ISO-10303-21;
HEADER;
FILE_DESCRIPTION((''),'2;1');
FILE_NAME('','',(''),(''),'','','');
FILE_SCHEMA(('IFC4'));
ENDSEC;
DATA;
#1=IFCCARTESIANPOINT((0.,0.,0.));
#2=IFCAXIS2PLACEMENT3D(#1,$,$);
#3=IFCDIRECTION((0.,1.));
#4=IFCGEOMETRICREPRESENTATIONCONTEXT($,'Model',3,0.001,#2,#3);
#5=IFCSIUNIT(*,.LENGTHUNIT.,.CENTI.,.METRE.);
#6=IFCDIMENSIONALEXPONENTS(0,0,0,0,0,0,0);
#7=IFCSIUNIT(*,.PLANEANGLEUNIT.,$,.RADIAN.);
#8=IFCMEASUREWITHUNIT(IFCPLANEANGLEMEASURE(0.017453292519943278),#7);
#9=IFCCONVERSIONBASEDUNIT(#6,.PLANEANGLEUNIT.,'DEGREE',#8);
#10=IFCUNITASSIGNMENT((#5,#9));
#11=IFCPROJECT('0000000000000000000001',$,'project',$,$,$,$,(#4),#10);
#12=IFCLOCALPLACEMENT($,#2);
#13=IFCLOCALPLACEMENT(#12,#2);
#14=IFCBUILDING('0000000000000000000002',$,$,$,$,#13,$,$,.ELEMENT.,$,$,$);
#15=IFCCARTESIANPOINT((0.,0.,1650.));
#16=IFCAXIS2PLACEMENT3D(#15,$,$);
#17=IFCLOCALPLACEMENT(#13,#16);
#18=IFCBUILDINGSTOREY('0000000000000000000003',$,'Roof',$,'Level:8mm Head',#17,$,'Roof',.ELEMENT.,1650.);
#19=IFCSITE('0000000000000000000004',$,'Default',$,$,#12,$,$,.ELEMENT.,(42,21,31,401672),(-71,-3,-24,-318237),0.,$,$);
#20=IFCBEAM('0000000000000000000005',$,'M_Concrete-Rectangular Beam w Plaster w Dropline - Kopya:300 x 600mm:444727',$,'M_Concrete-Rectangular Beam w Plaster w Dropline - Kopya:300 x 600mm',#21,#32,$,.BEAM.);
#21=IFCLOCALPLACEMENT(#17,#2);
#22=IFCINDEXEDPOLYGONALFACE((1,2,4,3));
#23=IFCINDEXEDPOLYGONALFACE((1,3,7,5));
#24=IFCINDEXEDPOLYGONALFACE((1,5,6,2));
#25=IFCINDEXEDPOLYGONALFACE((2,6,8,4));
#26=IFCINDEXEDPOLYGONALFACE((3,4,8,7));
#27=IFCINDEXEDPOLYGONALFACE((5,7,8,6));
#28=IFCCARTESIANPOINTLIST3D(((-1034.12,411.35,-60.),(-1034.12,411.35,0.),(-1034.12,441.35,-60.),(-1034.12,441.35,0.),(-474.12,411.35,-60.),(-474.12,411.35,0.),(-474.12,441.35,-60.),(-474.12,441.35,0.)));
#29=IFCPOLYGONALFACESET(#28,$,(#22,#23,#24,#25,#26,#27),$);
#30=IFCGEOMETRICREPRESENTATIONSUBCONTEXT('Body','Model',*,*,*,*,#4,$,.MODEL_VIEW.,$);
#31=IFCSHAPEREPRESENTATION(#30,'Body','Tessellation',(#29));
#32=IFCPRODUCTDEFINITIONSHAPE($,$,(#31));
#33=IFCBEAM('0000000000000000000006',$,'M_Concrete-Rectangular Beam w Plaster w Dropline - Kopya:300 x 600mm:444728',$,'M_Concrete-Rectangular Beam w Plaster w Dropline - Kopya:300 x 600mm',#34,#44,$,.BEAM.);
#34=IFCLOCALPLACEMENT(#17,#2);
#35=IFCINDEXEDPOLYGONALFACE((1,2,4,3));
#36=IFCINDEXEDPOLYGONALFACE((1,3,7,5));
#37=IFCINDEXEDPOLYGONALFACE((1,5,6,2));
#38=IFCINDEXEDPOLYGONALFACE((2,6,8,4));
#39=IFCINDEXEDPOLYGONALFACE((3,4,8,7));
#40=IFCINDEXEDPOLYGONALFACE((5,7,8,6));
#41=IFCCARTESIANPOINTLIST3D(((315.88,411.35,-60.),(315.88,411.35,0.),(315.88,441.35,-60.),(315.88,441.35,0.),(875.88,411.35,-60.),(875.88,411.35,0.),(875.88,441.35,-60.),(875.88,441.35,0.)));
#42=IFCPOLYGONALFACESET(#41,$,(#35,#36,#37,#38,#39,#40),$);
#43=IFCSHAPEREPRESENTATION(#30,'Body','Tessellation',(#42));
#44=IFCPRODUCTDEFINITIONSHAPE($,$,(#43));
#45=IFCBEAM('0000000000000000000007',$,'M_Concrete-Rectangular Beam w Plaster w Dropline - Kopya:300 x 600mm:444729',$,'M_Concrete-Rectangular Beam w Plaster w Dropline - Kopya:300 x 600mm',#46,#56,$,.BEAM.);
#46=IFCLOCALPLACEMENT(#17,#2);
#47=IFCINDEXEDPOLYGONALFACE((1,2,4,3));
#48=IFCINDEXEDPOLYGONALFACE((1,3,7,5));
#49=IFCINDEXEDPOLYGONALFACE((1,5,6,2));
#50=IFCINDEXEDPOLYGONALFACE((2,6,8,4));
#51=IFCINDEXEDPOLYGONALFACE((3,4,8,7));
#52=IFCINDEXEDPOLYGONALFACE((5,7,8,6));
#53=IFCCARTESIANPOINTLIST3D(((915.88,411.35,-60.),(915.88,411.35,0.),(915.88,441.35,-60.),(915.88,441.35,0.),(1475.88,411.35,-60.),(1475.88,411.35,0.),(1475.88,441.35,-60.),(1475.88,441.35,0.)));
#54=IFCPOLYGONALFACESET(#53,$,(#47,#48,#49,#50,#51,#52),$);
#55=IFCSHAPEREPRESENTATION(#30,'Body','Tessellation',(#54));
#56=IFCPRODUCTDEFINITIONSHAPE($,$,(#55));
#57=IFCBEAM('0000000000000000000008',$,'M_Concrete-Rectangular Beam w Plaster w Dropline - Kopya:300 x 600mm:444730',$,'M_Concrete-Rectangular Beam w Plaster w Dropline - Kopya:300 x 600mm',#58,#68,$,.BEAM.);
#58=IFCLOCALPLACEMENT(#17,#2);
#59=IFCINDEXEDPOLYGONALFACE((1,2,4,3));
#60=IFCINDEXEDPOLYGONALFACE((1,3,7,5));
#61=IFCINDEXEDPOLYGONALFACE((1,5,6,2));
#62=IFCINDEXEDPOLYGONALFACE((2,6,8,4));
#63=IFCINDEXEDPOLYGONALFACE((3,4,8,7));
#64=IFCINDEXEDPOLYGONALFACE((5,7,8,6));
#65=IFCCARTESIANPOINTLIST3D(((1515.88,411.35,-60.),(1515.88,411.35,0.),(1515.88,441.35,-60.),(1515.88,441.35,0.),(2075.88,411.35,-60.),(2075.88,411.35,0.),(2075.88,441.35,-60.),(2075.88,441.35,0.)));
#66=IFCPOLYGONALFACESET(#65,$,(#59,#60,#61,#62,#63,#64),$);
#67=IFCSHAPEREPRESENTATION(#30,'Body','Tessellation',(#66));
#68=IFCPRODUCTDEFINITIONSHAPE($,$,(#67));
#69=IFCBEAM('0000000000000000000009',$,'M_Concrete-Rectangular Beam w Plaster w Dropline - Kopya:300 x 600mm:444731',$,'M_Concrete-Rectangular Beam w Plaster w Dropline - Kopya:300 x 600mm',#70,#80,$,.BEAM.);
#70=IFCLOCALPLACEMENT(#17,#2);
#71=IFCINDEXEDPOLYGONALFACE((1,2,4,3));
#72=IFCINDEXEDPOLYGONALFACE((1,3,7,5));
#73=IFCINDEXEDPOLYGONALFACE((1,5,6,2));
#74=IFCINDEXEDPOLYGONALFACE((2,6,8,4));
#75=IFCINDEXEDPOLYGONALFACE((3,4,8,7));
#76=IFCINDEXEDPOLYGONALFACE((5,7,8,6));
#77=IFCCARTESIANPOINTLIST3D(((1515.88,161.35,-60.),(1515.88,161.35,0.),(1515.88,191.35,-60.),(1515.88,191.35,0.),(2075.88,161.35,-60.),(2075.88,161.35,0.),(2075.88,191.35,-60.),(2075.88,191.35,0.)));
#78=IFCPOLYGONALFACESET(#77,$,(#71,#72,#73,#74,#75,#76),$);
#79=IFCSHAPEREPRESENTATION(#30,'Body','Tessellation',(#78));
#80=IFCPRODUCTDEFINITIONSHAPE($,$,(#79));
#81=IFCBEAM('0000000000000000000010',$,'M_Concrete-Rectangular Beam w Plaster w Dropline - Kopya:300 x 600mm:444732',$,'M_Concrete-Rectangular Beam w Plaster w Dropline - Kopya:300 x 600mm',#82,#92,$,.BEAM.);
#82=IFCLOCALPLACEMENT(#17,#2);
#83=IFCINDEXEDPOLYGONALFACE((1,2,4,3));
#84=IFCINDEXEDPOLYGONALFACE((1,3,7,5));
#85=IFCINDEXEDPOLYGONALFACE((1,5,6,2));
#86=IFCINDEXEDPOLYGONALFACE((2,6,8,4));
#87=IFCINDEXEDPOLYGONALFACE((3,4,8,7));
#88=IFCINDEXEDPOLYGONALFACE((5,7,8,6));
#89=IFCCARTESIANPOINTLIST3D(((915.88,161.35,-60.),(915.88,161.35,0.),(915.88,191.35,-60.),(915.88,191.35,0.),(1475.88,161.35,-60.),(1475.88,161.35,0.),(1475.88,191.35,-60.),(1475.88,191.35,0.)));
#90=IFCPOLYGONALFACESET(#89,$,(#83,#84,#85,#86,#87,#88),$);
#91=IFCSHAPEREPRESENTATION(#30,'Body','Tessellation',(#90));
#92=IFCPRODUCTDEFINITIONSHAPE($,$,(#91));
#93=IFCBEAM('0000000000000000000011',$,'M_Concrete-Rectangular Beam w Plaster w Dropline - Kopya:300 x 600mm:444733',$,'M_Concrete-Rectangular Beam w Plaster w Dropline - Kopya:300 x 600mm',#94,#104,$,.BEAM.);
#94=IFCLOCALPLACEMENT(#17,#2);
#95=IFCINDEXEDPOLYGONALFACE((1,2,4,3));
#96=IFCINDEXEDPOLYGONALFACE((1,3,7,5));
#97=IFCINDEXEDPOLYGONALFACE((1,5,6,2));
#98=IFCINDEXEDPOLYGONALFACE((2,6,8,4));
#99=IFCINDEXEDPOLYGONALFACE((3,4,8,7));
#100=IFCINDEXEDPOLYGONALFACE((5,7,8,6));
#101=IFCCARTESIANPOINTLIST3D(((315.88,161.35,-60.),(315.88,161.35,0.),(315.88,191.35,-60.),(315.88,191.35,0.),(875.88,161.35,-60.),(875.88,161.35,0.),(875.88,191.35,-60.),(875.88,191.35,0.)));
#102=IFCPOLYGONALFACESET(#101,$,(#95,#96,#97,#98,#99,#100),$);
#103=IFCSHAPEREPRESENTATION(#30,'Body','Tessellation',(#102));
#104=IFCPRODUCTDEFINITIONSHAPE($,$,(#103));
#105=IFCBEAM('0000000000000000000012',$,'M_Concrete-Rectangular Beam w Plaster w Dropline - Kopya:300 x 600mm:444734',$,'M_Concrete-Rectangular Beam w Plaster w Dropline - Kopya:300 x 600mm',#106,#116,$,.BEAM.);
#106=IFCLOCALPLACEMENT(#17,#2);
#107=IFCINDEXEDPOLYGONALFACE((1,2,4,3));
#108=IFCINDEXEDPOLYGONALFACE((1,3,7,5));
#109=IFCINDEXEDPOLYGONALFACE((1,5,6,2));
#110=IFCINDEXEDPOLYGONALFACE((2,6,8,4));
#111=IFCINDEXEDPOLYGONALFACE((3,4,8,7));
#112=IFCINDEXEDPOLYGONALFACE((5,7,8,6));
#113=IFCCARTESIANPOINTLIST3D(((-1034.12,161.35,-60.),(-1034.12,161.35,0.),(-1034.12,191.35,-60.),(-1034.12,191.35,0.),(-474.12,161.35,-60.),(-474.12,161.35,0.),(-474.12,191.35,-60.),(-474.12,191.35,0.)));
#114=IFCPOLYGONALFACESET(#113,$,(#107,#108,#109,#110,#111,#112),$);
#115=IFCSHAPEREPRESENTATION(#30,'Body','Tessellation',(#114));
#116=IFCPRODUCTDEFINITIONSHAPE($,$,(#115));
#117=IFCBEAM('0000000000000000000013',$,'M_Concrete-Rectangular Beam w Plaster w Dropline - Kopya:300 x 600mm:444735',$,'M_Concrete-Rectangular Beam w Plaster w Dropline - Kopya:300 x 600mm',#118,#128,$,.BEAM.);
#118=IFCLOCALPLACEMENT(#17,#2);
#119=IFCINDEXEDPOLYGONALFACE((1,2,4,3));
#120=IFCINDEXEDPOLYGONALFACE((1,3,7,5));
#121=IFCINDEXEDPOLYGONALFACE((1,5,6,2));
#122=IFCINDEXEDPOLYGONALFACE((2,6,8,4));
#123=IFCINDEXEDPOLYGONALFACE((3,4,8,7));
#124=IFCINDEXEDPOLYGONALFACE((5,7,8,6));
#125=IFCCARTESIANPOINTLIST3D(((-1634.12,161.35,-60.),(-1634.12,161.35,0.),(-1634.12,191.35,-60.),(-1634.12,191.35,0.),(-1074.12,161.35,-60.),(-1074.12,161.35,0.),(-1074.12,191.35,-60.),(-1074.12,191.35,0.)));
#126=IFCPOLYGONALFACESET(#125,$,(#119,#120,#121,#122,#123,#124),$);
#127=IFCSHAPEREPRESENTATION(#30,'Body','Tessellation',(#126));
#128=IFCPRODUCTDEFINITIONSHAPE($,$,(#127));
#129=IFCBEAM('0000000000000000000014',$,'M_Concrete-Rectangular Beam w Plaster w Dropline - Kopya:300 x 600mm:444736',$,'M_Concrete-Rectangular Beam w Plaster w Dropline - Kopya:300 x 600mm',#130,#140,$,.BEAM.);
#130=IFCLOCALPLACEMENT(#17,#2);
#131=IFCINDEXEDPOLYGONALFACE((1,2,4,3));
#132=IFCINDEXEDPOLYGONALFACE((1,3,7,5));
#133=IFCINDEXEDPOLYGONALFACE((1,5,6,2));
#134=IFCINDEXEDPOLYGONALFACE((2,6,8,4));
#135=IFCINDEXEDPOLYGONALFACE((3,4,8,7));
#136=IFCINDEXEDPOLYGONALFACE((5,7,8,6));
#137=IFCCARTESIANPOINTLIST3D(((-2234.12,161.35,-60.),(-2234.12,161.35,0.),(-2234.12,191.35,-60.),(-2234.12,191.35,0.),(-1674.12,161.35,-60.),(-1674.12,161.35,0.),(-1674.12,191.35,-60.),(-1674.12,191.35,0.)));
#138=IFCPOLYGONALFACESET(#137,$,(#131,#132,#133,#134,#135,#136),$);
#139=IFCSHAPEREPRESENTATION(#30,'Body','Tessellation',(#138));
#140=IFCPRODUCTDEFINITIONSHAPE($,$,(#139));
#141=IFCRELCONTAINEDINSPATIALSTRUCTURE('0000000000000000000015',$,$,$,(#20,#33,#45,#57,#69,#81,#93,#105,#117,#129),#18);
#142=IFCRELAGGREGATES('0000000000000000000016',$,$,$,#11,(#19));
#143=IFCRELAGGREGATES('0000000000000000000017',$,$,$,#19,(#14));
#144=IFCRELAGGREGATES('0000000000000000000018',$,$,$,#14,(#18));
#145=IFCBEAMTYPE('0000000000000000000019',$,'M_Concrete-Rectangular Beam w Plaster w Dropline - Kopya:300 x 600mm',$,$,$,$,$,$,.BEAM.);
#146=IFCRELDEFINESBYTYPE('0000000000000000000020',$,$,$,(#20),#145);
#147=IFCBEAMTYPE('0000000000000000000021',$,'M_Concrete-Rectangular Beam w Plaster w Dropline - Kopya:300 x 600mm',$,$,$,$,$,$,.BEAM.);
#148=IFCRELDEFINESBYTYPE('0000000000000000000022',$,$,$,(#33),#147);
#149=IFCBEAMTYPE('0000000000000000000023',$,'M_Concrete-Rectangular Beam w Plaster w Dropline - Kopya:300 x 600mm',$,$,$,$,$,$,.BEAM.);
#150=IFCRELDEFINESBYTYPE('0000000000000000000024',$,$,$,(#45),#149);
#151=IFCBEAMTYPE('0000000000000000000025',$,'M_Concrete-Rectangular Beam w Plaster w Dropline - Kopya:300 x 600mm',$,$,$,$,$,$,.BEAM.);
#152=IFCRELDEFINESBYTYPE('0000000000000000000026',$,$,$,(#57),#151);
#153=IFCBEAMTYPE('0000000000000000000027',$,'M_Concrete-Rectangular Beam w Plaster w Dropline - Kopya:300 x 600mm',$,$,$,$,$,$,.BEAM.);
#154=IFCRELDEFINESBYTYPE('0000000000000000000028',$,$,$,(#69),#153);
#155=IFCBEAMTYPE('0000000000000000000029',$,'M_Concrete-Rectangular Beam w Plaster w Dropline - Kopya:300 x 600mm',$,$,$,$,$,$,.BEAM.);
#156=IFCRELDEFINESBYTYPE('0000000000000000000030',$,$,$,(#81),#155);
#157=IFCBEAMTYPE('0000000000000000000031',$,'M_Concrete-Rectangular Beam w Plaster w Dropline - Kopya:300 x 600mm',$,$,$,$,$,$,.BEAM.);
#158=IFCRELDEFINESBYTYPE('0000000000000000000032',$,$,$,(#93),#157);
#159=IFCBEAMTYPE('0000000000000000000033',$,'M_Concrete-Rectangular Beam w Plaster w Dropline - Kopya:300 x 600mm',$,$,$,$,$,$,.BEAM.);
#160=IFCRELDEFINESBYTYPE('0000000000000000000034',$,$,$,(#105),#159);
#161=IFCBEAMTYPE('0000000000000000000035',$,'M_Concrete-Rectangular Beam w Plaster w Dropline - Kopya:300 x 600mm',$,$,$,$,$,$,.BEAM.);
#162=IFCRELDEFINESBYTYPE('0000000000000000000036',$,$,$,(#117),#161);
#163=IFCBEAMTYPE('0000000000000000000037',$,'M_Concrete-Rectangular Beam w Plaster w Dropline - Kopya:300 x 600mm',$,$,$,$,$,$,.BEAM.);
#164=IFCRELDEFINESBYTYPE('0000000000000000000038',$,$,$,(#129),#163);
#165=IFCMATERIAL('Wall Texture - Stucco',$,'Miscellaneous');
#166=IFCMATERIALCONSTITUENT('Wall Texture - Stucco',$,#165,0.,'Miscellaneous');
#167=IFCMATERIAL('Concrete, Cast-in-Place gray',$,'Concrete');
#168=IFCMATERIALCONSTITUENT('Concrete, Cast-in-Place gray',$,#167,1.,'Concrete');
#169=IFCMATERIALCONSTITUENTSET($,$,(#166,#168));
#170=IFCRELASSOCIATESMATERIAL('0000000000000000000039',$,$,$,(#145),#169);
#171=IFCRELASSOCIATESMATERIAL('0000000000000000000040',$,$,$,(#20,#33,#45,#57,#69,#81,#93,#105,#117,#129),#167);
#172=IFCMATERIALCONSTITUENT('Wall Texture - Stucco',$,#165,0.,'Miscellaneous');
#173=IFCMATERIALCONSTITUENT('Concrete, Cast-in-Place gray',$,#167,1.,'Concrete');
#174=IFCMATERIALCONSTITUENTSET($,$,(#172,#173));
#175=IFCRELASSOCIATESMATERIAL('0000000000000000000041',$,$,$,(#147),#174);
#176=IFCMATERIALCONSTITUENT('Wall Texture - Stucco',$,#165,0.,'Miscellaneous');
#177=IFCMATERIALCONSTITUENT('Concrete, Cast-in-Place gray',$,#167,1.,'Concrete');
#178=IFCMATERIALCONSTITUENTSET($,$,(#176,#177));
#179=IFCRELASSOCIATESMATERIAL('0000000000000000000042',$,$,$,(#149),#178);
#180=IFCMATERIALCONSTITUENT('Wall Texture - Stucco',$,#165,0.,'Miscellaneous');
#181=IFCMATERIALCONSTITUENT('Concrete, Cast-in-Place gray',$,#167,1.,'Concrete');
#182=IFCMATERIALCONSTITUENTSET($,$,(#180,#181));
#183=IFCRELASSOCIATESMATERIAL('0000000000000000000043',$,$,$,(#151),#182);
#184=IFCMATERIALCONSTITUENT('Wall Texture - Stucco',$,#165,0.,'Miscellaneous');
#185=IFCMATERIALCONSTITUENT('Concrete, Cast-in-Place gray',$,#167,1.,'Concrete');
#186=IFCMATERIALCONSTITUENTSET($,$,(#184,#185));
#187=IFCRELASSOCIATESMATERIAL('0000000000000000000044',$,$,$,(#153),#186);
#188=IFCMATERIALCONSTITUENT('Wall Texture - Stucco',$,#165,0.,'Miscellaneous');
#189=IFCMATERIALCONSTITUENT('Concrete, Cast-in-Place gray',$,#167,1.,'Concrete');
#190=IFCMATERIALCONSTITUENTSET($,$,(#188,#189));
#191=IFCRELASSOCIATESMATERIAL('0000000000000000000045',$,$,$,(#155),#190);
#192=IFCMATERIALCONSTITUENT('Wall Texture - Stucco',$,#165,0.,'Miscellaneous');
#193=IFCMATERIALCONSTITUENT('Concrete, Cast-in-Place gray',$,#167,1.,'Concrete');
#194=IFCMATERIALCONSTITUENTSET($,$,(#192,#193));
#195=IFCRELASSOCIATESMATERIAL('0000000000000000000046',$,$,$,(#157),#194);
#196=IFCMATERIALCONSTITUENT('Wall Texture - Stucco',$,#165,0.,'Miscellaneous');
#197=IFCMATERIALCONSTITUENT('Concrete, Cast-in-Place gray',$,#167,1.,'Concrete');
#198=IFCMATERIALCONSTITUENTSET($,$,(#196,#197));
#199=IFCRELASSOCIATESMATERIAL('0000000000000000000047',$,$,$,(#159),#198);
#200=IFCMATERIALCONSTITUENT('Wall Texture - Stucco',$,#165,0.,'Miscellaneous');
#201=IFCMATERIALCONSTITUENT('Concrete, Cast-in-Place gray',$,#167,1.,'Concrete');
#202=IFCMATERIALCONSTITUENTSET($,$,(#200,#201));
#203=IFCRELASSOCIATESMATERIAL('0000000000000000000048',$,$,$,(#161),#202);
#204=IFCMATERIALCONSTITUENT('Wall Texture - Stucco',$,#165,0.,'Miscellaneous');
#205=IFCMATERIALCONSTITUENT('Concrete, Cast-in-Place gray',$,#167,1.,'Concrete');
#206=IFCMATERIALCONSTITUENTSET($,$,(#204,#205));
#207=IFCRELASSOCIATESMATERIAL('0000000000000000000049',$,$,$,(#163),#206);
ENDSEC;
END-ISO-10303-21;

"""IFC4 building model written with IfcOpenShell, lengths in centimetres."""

from ifc_helpers import new_model, entity, si_unit, converted_unit, direction, frame, origin, place, context, subcontext, project, spatial, indexed_curve, outline, extrude, source, transform, mapped, material, constituent, constituent_set, type_object, type_shapes, element, save


model = new_model("IFC4")

# Units and contexts
model_context = context("Model", 3, precision=0.001, world=origin(), true_north=direction((0.0, 1.0)))
body_context = subcontext(model_context, "Body", "Model", "MODEL_VIEW")
ifc_project = project(units=[si_unit("LENGTHUNIT", "METRE", prefix="CENTI"), converted_unit("PLANEANGLEUNIT", "DEGREE", entity("IfcPlaneAngleMeasure", 0.017453292519943278), si_unit("PLANEANGLEUNIT", "RADIAN"), dimensions=[0, 0, 0, 0, 0, 0, 0])], contexts=[model_context])

# Site, building, storey
site_placement = place(None, origin())
site = spatial("IfcSite", under=ifc_project, at=site_placement, Name="Default", CompositionType="ELEMENT", RefLatitude=(42, 21, 31, 401672), RefLongitude=(-71, -3, -24, -318237), RefElevation=0.0)
building_placement = place(site_placement, origin())
building = spatial("IfcBuilding", under=site, at=building_placement, CompositionType="ELEMENT")
storey_placement = place(building_placement, frame((0.0, 0.0, 1650.0)))
storey = spatial("IfcBuildingStorey", under=building, at=storey_placement, Name="Roof", ObjectType="Level:8mm Head", LongName="Roof", CompositionType="ELEMENT", Elevation=1650.0)

# Beams
ifc_material_1 = material(Name="Concrete, Cast-in-Place gray", Category="Concrete")
ifc_material_2 = material(Name="Wall Texture - Stucco", Category="Miscellaneous")
ifc_constituent_1 = constituent(ifc_material_2, Name="Wall Texture - Stucco", Category="Miscellaneous", fraction=0.0)
ifc_constituent_2 = constituent(ifc_material_1, Name="Concrete, Cast-in-Place gray", Category="Concrete", fraction=1.0)
ifc_constituent_set_1 = constituent_set(constituents=[ifc_constituent_1, ifc_constituent_2])
beam_type_1 = type_object("IfcBeamType", Name="M_Concrete-Rectangular Beam w Plaster w Dropline - Kopya:300 x 600mm", PredefinedType="BEAM", material=ifc_constituent_set_1)
shared_shape_1 = source(origin(), body_context, "Body", "SweptSolid", [
    extrude(outline(indexed_curve([(-30.0, -15.0), (30.0, -15.0), (30.0, 15.0), (-30.0, 15.0), (-30.0, -15.0)], self_intersect=False)), frame((-1034.12, 426.35, 1620.0), z_axis=(1.0, 0.0, 0.0), x_axis=(0.0, 0.0, -1.0)), (0.0, 0.0, 1.0), 560.0),
])
type_shapes(beam_type_1, [shared_shape_1])
beam_1_placement = place(storey_placement, frame((0.0, 0.0, -1650.0)))
element("IfcBeam", 1, at=beam_1_placement, inside=storey, type_object=beam_type_1, material=ifc_material_1, Name="M_Concrete-Rectangular Beam w Plaster w Dropline - Kopya:300 x 600mm:444727", ObjectType="M_Concrete-Rectangular Beam w Plaster w Dropline - Kopya:300 x 600mm", PredefinedType="BEAM", context=body_context, shape_type="MappedRepresentation", body=[
    mapped(shared_shape_1, transform((0.0, 0.0, 0.0), scale=1.0)),
])
ifc_constituent_3 = constituent(ifc_material_2, Name="Wall Texture - Stucco", Category="Miscellaneous", fraction=0.0)
ifc_constituent_4 = constituent(ifc_material_1, Name="Concrete, Cast-in-Place gray", Category="Concrete", fraction=1.0)
ifc_constituent_set_2 = constituent_set(constituents=[ifc_constituent_3, ifc_constituent_4])
beam_type_2 = type_object("IfcBeamType", Name="M_Concrete-Rectangular Beam w Plaster w Dropline - Kopya:300 x 600mm", PredefinedType="BEAM", material=ifc_constituent_set_2)
shared_shape_2 = source(origin(), body_context, "Body", "SweptSolid", [
    extrude(outline(indexed_curve([(-30.0, -15.0), (30.0, -15.0), (30.0, 15.0), (-30.0, 15.0), (-30.0, -15.0)], self_intersect=False)), frame((315.88, 426.35, 1620.0), z_axis=(1.0, 0.0, 0.0), x_axis=(0.0, 0.0, -1.0)), (0.0, 0.0, 1.0), 560.0),
])
type_shapes(beam_type_2, [shared_shape_2])
beam_2_placement = place(storey_placement, frame((0.0, 0.0, -1650.0)))
element("IfcBeam", 2, at=beam_2_placement, inside=storey, type_object=beam_type_2, material=ifc_material_1, Name="M_Concrete-Rectangular Beam w Plaster w Dropline - Kopya:300 x 600mm:444728", ObjectType="M_Concrete-Rectangular Beam w Plaster w Dropline - Kopya:300 x 600mm", PredefinedType="BEAM", context=body_context, shape_type="MappedRepresentation", body=[
    mapped(shared_shape_2, transform((0.0, 0.0, 0.0), scale=1.0)),
])
ifc_constituent_5 = constituent(ifc_material_2, Name="Wall Texture - Stucco", Category="Miscellaneous", fraction=0.0)
ifc_constituent_6 = constituent(ifc_material_1, Name="Concrete, Cast-in-Place gray", Category="Concrete", fraction=1.0)
ifc_constituent_set_3 = constituent_set(constituents=[ifc_constituent_5, ifc_constituent_6])
beam_type_3 = type_object("IfcBeamType", Name="M_Concrete-Rectangular Beam w Plaster w Dropline - Kopya:300 x 600mm", PredefinedType="BEAM", material=ifc_constituent_set_3)
shared_shape_3 = source(origin(), body_context, "Body", "SweptSolid", [
    extrude(outline(indexed_curve([(-30.0, -15.0), (30.0, -15.0), (30.0, 15.0), (-30.0, 15.0), (-30.0, -15.0)], self_intersect=False)), frame((915.88, 426.35, 1620.0), z_axis=(1.0, 0.0, 0.0), x_axis=(0.0, 0.0, -1.0)), (0.0, 0.0, 1.0), 560.0),
])
type_shapes(beam_type_3, [shared_shape_3])
beam_3_placement = place(storey_placement, frame((0.0, 0.0, -1650.0)))
element("IfcBeam", 3, at=beam_3_placement, inside=storey, type_object=beam_type_3, material=ifc_material_1, Name="M_Concrete-Rectangular Beam w Plaster w Dropline - Kopya:300 x 600mm:444729", ObjectType="M_Concrete-Rectangular Beam w Plaster w Dropline - Kopya:300 x 600mm", PredefinedType="BEAM", context=body_context, shape_type="MappedRepresentation", body=[
    mapped(shared_shape_3, transform((0.0, 0.0, 0.0), scale=1.0)),
])
ifc_constituent_7 = constituent(ifc_material_2, Name="Wall Texture - Stucco", Category="Miscellaneous", fraction=0.0)
ifc_constituent_8 = constituent(ifc_material_1, Name="Concrete, Cast-in-Place gray", Category="Concrete", fraction=1.0)
ifc_constituent_set_4 = constituent_set(constituents=[ifc_constituent_7, ifc_constituent_8])
beam_type_4 = type_object("IfcBeamType", Name="M_Concrete-Rectangular Beam w Plaster w Dropline - Kopya:300 x 600mm", PredefinedType="BEAM", material=ifc_constituent_set_4)
shared_shape_4 = source(origin(), body_context, "Body", "SweptSolid", [
    extrude(outline(indexed_curve([(-30.0, -15.0), (30.0, -15.0), (30.0, 15.0), (-30.0, 15.0), (-30.0, -15.0)], self_intersect=False)), frame((1515.88, 426.35, 1620.0), z_axis=(1.0, 0.0, 0.0), x_axis=(0.0, 0.0, -1.0)), (0.0, 0.0, 1.0), 560.0),
])
type_shapes(beam_type_4, [shared_shape_4])
beam_4_placement = place(storey_placement, frame((0.0, 0.0, -1650.0)))
element("IfcBeam", 4, at=beam_4_placement, inside=storey, type_object=beam_type_4, material=ifc_material_1, Name="M_Concrete-Rectangular Beam w Plaster w Dropline - Kopya:300 x 600mm:444730", ObjectType="M_Concrete-Rectangular Beam w Plaster w Dropline - Kopya:300 x 600mm", PredefinedType="BEAM", context=body_context, shape_type="MappedRepresentation", body=[
    mapped(shared_shape_4, transform((0.0, 0.0, 0.0), scale=1.0)),
])
ifc_constituent_9 = constituent(ifc_material_2, Name="Wall Texture - Stucco", Category="Miscellaneous", fraction=0.0)
ifc_constituent_10 = constituent(ifc_material_1, Name="Concrete, Cast-in-Place gray", Category="Concrete", fraction=1.0)
ifc_constituent_set_5 = constituent_set(constituents=[ifc_constituent_9, ifc_constituent_10])
beam_type_5 = type_object("IfcBeamType", Name="M_Concrete-Rectangular Beam w Plaster w Dropline - Kopya:300 x 600mm", PredefinedType="BEAM", material=ifc_constituent_set_5)
shared_shape_5 = source(origin(), body_context, "Body", "SweptSolid", [
    extrude(outline(indexed_curve([(-30.0, -15.0), (30.0, -15.0), (30.0, 15.0), (-30.0, 15.0), (-30.0, -15.0)], self_intersect=False)), frame((2075.88, 176.35, 1620.0), z_axis=(-1.0, 0.0, 0.0), x_axis=(0.0, 0.0, -1.0)), (0.0, 0.0, 1.0), 560.0),
])
type_shapes(beam_type_5, [shared_shape_5])
beam_5_placement = place(storey_placement, frame((0.0, 0.0, -1650.0)))
element("IfcBeam", 5, at=beam_5_placement, inside=storey, type_object=beam_type_5, material=ifc_material_1, Name="M_Concrete-Rectangular Beam w Plaster w Dropline - Kopya:300 x 600mm:444731", ObjectType="M_Concrete-Rectangular Beam w Plaster w Dropline - Kopya:300 x 600mm", PredefinedType="BEAM", context=body_context, shape_type="MappedRepresentation", body=[
    mapped(shared_shape_5, transform((0.0, 0.0, 0.0), scale=1.0)),
])
ifc_constituent_11 = constituent(ifc_material_2, Name="Wall Texture - Stucco", Category="Miscellaneous", fraction=0.0)
ifc_constituent_12 = constituent(ifc_material_1, Name="Concrete, Cast-in-Place gray", Category="Concrete", fraction=1.0)
ifc_constituent_set_6 = constituent_set(constituents=[ifc_constituent_11, ifc_constituent_12])
beam_type_6 = type_object("IfcBeamType", Name="M_Concrete-Rectangular Beam w Plaster w Dropline - Kopya:300 x 600mm", PredefinedType="BEAM", material=ifc_constituent_set_6)
shared_shape_6 = source(origin(), body_context, "Body", "SweptSolid", [
    extrude(outline(indexed_curve([(-30.0, -15.0), (30.0, -15.0), (30.0, 15.0), (-30.0, 15.0), (-30.0, -15.0)], self_intersect=False)), frame((1475.88, 176.35, 1620.0), z_axis=(-1.0, 0.0, 0.0), x_axis=(0.0, 0.0, -1.0)), (0.0, 0.0, 1.0), 560.0),
])
type_shapes(beam_type_6, [shared_shape_6])
beam_6_placement = place(storey_placement, frame((0.0, 0.0, -1650.0)))
element("IfcBeam", 6, at=beam_6_placement, inside=storey, type_object=beam_type_6, material=ifc_material_1, Name="M_Concrete-Rectangular Beam w Plaster w Dropline - Kopya:300 x 600mm:444732", ObjectType="M_Concrete-Rectangular Beam w Plaster w Dropline - Kopya:300 x 600mm", PredefinedType="BEAM", context=body_context, shape_type="MappedRepresentation", body=[
    mapped(shared_shape_6, transform((0.0, 0.0, 0.0), scale=1.0)),
])
ifc_constituent_13 = constituent(ifc_material_2, Name="Wall Texture - Stucco", Category="Miscellaneous", fraction=0.0)
ifc_constituent_14 = constituent(ifc_material_1, Name="Concrete, Cast-in-Place gray", Category="Concrete", fraction=1.0)
ifc_constituent_set_7 = constituent_set(constituents=[ifc_constituent_13, ifc_constituent_14])
beam_type_7 = type_object("IfcBeamType", Name="M_Concrete-Rectangular Beam w Plaster w Dropline - Kopya:300 x 600mm", PredefinedType="BEAM", material=ifc_constituent_set_7)
shared_shape_7 = source(origin(), body_context, "Body", "SweptSolid", [
    extrude(outline(indexed_curve([(-30.0, -15.0), (30.0, -15.0), (30.0, 15.0), (-30.0, 15.0), (-30.0, -15.0)], self_intersect=False)), frame((875.88, 176.35, 1620.0), z_axis=(-1.0, 0.0, 0.0), x_axis=(0.0, 0.0, -1.0)), (0.0, 0.0, 1.0), 560.0),
])
type_shapes(beam_type_7, [shared_shape_7])
beam_7_placement = place(storey_placement, frame((0.0, 0.0, -1650.0)))
element("IfcBeam", 7, at=beam_7_placement, inside=storey, type_object=beam_type_7, material=ifc_material_1, Name="M_Concrete-Rectangular Beam w Plaster w Dropline - Kopya:300 x 600mm:444733", ObjectType="M_Concrete-Rectangular Beam w Plaster w Dropline - Kopya:300 x 600mm", PredefinedType="BEAM", context=body_context, shape_type="MappedRepresentation", body=[
    mapped(shared_shape_7, transform((0.0, 0.0, 0.0), scale=1.0)),
])
ifc_constituent_15 = constituent(ifc_material_2, Name="Wall Texture - Stucco", Category="Miscellaneous", fraction=0.0)
ifc_constituent_16 = constituent(ifc_material_1, Name="Concrete, Cast-in-Place gray", Category="Concrete", fraction=1.0)
ifc_constituent_set_8 = constituent_set(constituents=[ifc_constituent_15, ifc_constituent_16])
beam_type_8 = type_object("IfcBeamType", Name="M_Concrete-Rectangular Beam w Plaster w Dropline - Kopya:300 x 600mm", PredefinedType="BEAM", material=ifc_constituent_set_8)
shared_shape_8 = source(origin(), body_context, "Body", "SweptSolid", [
    extrude(outline(indexed_curve([(-30.0, -15.0), (30.0, -15.0), (30.0, 15.0), (-30.0, 15.0), (-30.0, -15.0)], self_intersect=False)), frame((-474.12, 176.35, 1620.0), z_axis=(-1.0, 0.0, 0.0), x_axis=(0.0, 0.0, -1.0)), (0.0, 0.0, 1.0), 560.0),
])
type_shapes(beam_type_8, [shared_shape_8])
beam_8_placement = place(storey_placement, frame((0.0, 0.0, -1650.0)))
element("IfcBeam", 8, at=beam_8_placement, inside=storey, type_object=beam_type_8, material=ifc_material_1, Name="M_Concrete-Rectangular Beam w Plaster w Dropline - Kopya:300 x 600mm:444734", ObjectType="M_Concrete-Rectangular Beam w Plaster w Dropline - Kopya:300 x 600mm", PredefinedType="BEAM", context=body_context, shape_type="MappedRepresentation", body=[
    mapped(shared_shape_8, transform((0.0, 0.0, 0.0), scale=1.0)),
])
ifc_constituent_17 = constituent(ifc_material_2, Name="Wall Texture - Stucco", Category="Miscellaneous", fraction=0.0)
ifc_constituent_18 = constituent(ifc_material_1, Name="Concrete, Cast-in-Place gray", Category="Concrete", fraction=1.0)
ifc_constituent_set_9 = constituent_set(constituents=[ifc_constituent_17, ifc_constituent_18])
beam_type_9 = type_object("IfcBeamType", Name="M_Concrete-Rectangular Beam w Plaster w Dropline - Kopya:300 x 600mm", PredefinedType="BEAM", material=ifc_constituent_set_9)
shared_shape_9 = source(origin(), body_context, "Body", "SweptSolid", [
    extrude(outline(indexed_curve([(-30.0, -15.0), (30.0, -15.0), (30.0, 15.0), (-30.0, 15.0), (-30.0, -15.0)], self_intersect=False)), frame((-1074.12, 176.35, 1620.0), z_axis=(-1.0, 0.0, 0.0), x_axis=(0.0, 0.0, -1.0)), (0.0, 0.0, 1.0), 560.0),
])
type_shapes(beam_type_9, [shared_shape_9])
beam_9_placement = place(storey_placement, frame((0.0, 0.0, -1650.0)))
element("IfcBeam", 9, at=beam_9_placement, inside=storey, type_object=beam_type_9, material=ifc_material_1, Name="M_Concrete-Rectangular Beam w Plaster w Dropline - Kopya:300 x 600mm:444735", ObjectType="M_Concrete-Rectangular Beam w Plaster w Dropline - Kopya:300 x 600mm", PredefinedType="BEAM", context=body_context, shape_type="MappedRepresentation", body=[
    mapped(shared_shape_9, transform((0.0, 0.0, 0.0), scale=1.0)),
])
ifc_constituent_19 = constituent(ifc_material_2, Name="Wall Texture - Stucco", Category="Miscellaneous", fraction=0.0)
ifc_constituent_20 = constituent(ifc_material_1, Name="Concrete, Cast-in-Place gray", Category="Concrete", fraction=1.0)
ifc_constituent_set_10 = constituent_set(constituents=[ifc_constituent_19, ifc_constituent_20])
beam_type_10 = type_object("IfcBeamType", Name="M_Concrete-Rectangular Beam w Plaster w Dropline - Kopya:300 x 600mm", PredefinedType="BEAM", material=ifc_constituent_set_10)
shared_shape_10 = source(origin(), body_context, "Body", "SweptSolid", [
    extrude(outline(indexed_curve([(-30.0, -15.0), (30.0, -15.0), (30.0, 15.0), (-30.0, 15.0), (-30.0, -15.0)], self_intersect=False)), frame((-1674.12, 176.35, 1620.0), z_axis=(-1.0, 0.0, 0.0), x_axis=(0.0, 0.0, -1.0)), (0.0, 0.0, 1.0), 560.0),
])
type_shapes(beam_type_10, [shared_shape_10])
beam_10_placement = place(storey_placement, frame((0.0, 0.0, -1650.0)))
element("IfcBeam", 10, at=beam_10_placement, inside=storey, type_object=beam_type_10, material=ifc_material_1, Name="M_Concrete-Rectangular Beam w Plaster w Dropline - Kopya:300 x 600mm:444736", ObjectType="M_Concrete-Rectangular Beam w Plaster w Dropline - Kopya:300 x 600mm", PredefinedType="BEAM", context=body_context, shape_type="MappedRepresentation", body=[
    mapped(shared_shape_10, transform((0.0, 0.0, 0.0), scale=1.0)),
])

save(model, "model.ifc")
